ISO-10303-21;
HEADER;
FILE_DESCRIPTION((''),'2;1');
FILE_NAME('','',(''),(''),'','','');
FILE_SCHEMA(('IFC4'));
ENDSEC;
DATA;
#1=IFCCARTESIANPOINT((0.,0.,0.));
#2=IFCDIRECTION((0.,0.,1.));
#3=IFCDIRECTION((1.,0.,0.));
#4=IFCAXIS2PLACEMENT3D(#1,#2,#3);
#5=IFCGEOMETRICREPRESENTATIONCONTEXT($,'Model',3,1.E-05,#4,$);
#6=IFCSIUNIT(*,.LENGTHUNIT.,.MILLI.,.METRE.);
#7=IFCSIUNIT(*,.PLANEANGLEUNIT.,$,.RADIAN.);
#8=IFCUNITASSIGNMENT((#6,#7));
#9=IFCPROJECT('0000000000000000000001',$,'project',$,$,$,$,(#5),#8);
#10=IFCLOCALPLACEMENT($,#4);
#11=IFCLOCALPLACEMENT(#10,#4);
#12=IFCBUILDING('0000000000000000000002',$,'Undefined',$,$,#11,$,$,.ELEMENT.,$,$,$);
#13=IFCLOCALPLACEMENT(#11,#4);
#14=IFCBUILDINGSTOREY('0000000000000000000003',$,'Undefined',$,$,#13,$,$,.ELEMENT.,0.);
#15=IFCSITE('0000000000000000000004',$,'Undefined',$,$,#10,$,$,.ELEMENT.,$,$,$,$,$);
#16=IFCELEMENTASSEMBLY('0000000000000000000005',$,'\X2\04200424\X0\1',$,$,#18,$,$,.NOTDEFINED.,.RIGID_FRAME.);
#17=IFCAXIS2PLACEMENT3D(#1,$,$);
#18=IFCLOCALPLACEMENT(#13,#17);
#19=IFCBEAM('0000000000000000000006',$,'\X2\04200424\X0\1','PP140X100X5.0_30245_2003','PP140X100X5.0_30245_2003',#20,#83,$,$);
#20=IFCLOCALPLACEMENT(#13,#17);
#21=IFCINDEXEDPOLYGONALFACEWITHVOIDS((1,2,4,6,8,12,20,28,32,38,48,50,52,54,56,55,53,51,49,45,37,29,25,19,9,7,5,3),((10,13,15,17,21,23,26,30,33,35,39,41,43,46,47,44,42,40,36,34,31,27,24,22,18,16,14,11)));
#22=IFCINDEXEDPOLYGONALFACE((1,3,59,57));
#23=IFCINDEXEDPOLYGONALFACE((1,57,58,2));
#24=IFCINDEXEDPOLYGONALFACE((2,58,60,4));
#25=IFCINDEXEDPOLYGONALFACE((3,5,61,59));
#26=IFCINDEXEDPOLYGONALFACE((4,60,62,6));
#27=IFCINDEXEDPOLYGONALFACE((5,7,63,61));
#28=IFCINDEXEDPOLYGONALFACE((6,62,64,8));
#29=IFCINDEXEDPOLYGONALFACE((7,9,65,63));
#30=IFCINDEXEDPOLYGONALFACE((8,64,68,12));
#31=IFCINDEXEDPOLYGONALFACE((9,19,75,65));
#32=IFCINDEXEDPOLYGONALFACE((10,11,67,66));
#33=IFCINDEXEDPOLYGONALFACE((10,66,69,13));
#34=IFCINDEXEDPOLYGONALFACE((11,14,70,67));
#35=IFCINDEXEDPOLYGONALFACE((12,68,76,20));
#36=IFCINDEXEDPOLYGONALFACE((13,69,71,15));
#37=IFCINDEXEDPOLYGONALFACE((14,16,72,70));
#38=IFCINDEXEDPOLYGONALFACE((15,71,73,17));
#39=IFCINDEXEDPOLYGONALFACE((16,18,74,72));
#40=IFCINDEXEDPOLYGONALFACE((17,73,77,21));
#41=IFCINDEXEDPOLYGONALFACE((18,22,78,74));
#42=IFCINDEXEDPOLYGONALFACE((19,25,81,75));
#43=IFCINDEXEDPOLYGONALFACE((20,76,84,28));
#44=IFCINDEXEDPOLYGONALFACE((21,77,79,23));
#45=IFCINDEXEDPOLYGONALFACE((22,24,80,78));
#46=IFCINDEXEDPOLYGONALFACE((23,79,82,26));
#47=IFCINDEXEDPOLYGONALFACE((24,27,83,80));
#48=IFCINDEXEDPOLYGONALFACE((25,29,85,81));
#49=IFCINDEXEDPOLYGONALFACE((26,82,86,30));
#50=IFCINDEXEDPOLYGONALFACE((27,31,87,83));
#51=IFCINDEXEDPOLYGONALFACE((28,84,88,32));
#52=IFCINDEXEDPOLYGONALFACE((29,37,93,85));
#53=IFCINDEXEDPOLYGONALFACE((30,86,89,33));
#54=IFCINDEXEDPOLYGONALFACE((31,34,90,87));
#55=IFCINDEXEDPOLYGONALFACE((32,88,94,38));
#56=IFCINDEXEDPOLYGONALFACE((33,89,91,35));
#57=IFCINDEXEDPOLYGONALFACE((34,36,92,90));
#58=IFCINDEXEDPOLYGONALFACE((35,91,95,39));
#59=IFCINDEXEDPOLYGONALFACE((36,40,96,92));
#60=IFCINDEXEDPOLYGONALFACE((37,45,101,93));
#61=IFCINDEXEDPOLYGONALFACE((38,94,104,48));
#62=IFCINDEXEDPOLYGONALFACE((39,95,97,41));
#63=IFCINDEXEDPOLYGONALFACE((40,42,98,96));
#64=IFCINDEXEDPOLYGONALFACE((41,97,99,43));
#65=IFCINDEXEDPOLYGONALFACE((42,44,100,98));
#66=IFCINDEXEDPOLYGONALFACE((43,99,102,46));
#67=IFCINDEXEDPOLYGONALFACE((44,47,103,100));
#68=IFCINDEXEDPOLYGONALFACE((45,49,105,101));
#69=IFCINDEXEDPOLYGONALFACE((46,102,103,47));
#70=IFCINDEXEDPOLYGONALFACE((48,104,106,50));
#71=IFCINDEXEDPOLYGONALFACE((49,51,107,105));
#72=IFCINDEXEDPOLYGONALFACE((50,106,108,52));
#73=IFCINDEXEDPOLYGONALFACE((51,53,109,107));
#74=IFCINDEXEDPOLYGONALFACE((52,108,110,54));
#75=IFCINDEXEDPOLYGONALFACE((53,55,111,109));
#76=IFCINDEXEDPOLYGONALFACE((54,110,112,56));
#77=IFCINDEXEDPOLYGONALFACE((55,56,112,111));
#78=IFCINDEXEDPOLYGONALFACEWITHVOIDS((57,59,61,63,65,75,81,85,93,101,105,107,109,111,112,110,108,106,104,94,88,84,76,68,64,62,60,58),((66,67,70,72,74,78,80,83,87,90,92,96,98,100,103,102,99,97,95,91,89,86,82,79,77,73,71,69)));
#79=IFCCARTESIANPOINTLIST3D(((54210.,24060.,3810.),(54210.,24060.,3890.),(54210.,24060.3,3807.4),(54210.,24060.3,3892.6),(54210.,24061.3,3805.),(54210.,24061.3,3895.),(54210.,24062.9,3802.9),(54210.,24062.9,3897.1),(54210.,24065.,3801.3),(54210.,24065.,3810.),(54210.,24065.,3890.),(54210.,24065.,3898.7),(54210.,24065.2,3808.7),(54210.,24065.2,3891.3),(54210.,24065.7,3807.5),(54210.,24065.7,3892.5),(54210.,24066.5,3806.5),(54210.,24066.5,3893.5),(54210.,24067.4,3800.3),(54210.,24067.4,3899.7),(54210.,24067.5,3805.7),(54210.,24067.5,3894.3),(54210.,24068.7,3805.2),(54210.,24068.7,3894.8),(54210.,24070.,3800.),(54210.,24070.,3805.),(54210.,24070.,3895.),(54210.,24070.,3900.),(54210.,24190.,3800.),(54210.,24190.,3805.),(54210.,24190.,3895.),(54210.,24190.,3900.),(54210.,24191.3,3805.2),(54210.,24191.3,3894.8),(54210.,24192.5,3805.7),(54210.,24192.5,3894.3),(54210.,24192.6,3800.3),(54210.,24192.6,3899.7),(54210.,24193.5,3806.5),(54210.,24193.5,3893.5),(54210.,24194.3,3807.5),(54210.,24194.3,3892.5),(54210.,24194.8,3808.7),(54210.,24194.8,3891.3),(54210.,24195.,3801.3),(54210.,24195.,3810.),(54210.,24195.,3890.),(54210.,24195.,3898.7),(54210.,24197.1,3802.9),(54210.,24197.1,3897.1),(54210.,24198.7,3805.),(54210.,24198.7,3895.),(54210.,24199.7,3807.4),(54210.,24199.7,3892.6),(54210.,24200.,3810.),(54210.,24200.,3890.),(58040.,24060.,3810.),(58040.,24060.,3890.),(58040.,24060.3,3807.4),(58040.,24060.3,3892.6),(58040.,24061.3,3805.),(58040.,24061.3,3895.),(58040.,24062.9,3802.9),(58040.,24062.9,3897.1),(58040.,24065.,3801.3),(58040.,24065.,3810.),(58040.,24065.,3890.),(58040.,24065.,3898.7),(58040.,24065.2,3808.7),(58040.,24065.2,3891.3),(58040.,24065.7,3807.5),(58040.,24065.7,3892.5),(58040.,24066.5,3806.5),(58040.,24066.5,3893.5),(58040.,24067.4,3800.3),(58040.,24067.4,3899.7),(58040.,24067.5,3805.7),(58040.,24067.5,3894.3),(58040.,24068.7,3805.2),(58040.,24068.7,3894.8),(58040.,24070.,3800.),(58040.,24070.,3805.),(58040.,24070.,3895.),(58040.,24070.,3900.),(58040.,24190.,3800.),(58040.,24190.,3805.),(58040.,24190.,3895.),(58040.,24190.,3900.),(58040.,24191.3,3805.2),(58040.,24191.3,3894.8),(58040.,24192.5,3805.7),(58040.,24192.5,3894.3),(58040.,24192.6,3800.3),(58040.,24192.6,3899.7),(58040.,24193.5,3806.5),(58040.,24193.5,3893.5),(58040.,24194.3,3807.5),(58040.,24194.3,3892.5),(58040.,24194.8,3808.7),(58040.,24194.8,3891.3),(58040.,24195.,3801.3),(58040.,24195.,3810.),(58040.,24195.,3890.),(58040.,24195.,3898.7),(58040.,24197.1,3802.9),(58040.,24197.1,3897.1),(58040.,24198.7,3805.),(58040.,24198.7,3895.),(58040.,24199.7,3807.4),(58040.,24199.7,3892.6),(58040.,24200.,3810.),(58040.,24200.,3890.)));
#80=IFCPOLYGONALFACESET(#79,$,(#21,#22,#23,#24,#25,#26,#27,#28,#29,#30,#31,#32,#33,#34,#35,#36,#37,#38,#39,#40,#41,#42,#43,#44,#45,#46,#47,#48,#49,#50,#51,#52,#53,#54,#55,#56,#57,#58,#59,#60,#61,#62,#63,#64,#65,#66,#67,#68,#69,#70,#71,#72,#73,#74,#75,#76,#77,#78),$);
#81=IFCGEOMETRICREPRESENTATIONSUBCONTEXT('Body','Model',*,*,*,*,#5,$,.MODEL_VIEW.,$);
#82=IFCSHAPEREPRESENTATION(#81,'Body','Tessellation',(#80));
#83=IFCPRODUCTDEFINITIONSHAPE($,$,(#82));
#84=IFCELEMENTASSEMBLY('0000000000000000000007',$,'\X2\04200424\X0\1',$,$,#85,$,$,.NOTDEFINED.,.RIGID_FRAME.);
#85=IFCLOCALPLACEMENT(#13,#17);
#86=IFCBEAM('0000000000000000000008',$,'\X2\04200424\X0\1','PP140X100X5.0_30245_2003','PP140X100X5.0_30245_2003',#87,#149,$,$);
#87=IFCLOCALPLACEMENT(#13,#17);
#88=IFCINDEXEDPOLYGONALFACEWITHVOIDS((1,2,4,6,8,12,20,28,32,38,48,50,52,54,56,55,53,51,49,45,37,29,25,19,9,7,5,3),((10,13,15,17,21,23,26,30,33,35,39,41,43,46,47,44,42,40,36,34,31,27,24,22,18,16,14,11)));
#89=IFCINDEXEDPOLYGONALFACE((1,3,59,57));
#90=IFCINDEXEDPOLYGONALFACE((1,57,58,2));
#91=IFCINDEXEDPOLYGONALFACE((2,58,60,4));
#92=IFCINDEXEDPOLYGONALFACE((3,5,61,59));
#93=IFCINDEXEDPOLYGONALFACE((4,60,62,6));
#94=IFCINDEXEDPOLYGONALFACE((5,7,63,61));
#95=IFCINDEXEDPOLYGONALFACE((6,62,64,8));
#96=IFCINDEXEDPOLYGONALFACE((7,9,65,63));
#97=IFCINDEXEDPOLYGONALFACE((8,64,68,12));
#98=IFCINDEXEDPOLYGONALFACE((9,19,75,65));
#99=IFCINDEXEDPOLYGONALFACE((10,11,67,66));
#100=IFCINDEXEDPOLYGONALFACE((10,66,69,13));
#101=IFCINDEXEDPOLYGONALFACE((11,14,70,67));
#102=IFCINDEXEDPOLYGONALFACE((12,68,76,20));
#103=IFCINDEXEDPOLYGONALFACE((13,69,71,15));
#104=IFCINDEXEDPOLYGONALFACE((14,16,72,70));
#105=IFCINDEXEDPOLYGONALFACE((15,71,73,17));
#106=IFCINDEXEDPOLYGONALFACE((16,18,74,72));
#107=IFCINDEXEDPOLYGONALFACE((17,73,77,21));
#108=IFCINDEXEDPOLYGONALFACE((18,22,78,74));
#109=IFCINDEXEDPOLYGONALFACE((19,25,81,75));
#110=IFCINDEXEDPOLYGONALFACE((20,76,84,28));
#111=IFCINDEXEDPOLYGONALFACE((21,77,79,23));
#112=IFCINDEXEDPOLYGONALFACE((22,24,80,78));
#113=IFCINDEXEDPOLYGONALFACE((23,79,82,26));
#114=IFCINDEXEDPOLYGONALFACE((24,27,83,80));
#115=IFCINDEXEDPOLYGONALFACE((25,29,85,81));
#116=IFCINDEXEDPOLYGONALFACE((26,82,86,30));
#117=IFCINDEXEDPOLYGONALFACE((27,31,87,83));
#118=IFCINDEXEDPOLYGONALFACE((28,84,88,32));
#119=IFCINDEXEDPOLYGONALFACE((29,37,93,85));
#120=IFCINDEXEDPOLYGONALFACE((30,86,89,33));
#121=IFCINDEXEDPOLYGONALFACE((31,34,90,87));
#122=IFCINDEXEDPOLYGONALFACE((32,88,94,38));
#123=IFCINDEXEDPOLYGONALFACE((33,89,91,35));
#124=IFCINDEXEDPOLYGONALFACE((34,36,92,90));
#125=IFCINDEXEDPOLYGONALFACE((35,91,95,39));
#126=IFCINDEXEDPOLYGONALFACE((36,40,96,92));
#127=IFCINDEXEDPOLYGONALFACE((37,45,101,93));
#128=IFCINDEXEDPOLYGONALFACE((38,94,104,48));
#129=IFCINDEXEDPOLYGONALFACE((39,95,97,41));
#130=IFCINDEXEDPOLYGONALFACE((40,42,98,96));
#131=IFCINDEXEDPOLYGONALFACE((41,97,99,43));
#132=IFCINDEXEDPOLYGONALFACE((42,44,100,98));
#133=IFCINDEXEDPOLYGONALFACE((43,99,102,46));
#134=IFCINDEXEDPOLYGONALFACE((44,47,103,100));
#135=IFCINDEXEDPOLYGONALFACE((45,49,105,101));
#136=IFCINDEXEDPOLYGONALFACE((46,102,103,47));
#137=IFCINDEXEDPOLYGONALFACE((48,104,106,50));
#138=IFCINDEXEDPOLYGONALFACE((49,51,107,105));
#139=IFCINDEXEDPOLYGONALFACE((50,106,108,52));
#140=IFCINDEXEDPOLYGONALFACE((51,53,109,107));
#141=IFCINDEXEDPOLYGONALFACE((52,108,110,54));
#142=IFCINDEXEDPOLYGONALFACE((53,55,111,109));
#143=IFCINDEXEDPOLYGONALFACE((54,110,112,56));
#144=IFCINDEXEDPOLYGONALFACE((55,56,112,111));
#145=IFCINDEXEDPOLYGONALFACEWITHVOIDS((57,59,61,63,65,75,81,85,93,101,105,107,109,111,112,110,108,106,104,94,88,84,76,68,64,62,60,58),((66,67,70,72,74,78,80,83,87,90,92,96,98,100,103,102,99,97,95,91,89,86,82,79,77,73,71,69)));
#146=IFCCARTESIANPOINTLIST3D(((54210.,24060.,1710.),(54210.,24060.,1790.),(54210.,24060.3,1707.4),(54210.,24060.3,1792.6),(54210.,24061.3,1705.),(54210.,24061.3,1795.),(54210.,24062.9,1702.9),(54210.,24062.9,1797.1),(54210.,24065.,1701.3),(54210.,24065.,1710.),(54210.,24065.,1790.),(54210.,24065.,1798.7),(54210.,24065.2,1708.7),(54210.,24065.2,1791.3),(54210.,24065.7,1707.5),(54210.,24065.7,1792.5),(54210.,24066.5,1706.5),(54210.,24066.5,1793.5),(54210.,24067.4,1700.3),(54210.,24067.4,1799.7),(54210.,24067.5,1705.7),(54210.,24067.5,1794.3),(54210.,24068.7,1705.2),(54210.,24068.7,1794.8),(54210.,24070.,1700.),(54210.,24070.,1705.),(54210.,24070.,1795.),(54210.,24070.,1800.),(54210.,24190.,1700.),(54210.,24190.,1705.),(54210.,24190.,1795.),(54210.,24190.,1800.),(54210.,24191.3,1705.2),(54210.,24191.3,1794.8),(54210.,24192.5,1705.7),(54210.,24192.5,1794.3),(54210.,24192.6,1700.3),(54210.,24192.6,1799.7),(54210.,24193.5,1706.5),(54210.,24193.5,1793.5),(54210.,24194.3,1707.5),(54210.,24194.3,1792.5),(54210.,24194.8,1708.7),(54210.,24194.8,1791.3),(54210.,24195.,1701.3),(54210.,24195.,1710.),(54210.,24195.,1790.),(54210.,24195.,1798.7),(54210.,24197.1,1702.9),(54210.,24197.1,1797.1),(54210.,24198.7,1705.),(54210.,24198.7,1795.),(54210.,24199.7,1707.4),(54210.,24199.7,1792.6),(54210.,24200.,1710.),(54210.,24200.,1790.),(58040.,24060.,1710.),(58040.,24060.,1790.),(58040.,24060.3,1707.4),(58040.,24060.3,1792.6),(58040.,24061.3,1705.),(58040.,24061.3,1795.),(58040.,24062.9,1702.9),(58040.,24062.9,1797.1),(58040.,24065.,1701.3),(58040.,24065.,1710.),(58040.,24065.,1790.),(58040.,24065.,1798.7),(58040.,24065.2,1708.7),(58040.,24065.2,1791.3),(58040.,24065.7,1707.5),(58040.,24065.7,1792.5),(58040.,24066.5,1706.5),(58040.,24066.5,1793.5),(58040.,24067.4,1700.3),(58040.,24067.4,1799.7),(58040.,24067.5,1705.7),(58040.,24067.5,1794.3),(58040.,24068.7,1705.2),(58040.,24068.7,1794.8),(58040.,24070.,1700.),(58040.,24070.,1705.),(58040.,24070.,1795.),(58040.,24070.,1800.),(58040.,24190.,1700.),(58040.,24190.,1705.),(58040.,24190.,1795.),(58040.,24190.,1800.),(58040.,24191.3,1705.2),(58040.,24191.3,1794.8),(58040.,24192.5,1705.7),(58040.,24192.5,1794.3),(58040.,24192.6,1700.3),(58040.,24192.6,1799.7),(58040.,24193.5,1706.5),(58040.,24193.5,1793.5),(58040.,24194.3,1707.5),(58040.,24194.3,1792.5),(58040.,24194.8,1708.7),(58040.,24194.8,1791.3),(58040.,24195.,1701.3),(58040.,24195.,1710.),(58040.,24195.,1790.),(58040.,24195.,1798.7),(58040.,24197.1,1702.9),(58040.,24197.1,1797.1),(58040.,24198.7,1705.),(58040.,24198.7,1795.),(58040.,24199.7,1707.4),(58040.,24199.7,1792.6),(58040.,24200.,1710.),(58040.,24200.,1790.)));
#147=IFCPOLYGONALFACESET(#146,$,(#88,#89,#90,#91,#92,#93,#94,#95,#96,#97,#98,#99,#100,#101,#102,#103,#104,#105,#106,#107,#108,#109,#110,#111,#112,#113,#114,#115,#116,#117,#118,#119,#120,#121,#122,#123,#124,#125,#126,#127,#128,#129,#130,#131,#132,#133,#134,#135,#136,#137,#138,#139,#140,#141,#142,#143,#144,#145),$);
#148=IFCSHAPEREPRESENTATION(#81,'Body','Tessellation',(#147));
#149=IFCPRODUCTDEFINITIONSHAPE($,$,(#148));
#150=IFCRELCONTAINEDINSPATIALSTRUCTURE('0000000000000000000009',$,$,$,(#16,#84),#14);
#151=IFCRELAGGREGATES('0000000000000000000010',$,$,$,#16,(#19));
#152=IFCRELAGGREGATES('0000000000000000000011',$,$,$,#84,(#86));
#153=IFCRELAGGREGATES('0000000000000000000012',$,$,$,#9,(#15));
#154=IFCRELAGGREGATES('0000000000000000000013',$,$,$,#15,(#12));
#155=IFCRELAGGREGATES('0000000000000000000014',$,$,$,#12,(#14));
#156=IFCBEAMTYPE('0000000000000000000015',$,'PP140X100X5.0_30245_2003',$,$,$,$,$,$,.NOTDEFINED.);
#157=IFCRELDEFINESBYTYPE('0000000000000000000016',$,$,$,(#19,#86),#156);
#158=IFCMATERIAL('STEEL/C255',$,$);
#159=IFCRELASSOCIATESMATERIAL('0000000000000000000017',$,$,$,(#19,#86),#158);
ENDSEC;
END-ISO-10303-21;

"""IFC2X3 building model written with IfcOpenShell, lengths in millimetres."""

from ifc_helpers import new_model, si_unit, frame, origin_with_axes, origin_2d_with_axis, place, context, subcontext, project, spatial, hollow_rectangle, extrude, material, type_object, element, aggregate, save


model = new_model("IFC2X3")

# Units and contexts
model_context = context("Model", 3, precision=1e-05, world=origin_with_axes())
body_context = subcontext(model_context, "Body", "Model", "MODEL_VIEW")
ifc_project = project(units=[si_unit("LENGTHUNIT", "METRE", prefix="MILLI"), si_unit("PLANEANGLEUNIT", "RADIAN")], contexts=[model_context])

# Site, building, storey
site_placement = place(None, origin_with_axes())
site = spatial("IfcSite", under=ifc_project, at=site_placement, Name="Undefined", CompositionType="ELEMENT")
building_placement = place(site_placement, origin_with_axes())
building = spatial("IfcBuilding", under=site, at=building_placement, Name="Undefined", CompositionType="ELEMENT")
storey_placement = place(building_placement, origin_with_axes())
storey = spatial("IfcBuildingStorey", under=building, at=storey_placement, Name="Undefined", CompositionType="ELEMENT", Elevation=0.0)

# Shared definitions
ifc_material_1 = material(Name="STEEL/C255")

# Element assemblies, beams
assembly_1_placement = place(storey_placement, origin_with_axes())
assembly_1 = element("IfcElementAssembly", 1, at=assembly_1_placement, inside=storey, Name="РФ1", AssemblyPlace="NOTDEFINED", PredefinedType="RIGID_FRAME")
beam_type_1 = type_object("IfcBeamType", Name="PP140X100X5.0_30245_2003", PredefinedType="NOTDEFINED")
beam_1_placement = place(assembly_1_placement, frame((54210.0, 24130.0, 3850.0), z_axis=(0.0, -1.0, 0.0), x_axis=(1.0, 0.0, 0.0)))
beam_1 = element("IfcBeam", 2, at=beam_1_placement, type_object=beam_type_1, material=ifc_material_1, Name="РФ1", Description="PP140X100X5.0_30245_2003", ObjectType="PP140X100X5.0_30245_2003", context=body_context, shape_type="SweptSolid", body=[
    extrude(hollow_rectangle(XDim=100.0, YDim=140.0, WallThickness=5.0, InnerFilletRadius=5.0, OuterFilletRadius=10.0, at=origin_2d_with_axis()), frame((3830.0, 0.0, 0.0), z_axis=(-1.0, 0.0, 0.0), x_axis=(0.0, -1.0, 0.0)), (0.0, 0.0, 1.0), 3830.0),
])
aggregate(assembly_1, [beam_1])
assembly_2_placement = place(storey_placement, origin_with_axes())
assembly_2 = element("IfcElementAssembly", 3, at=assembly_2_placement, inside=storey, Name="РФ1", AssemblyPlace="NOTDEFINED", PredefinedType="RIGID_FRAME")
beam_2_placement = place(assembly_2_placement, frame((54210.0, 24130.0, 1750.0), z_axis=(0.0, 1.0, 0.0), x_axis=(1.0, 0.0, 0.0)))
beam_2 = element("IfcBeam", 4, at=beam_2_placement, type_object=beam_type_1, material=ifc_material_1, Name="РФ1", Description="PP140X100X5.0_30245_2003", ObjectType="PP140X100X5.0_30245_2003", context=body_context, shape_type="SweptSolid", body=[
    extrude(hollow_rectangle(XDim=100.0, YDim=140.0, WallThickness=5.0, InnerFilletRadius=5.0, OuterFilletRadius=10.0, at=origin_2d_with_axis()), frame((3830.0, 0.0, 0.0), z_axis=(-1.0, 0.0, 0.0), x_axis=(0.0, -1.0, 0.0)), (0.0, 0.0, 1.0), 3830.0),
])
aggregate(assembly_2, [beam_2])

save(model, "model.ifc")
